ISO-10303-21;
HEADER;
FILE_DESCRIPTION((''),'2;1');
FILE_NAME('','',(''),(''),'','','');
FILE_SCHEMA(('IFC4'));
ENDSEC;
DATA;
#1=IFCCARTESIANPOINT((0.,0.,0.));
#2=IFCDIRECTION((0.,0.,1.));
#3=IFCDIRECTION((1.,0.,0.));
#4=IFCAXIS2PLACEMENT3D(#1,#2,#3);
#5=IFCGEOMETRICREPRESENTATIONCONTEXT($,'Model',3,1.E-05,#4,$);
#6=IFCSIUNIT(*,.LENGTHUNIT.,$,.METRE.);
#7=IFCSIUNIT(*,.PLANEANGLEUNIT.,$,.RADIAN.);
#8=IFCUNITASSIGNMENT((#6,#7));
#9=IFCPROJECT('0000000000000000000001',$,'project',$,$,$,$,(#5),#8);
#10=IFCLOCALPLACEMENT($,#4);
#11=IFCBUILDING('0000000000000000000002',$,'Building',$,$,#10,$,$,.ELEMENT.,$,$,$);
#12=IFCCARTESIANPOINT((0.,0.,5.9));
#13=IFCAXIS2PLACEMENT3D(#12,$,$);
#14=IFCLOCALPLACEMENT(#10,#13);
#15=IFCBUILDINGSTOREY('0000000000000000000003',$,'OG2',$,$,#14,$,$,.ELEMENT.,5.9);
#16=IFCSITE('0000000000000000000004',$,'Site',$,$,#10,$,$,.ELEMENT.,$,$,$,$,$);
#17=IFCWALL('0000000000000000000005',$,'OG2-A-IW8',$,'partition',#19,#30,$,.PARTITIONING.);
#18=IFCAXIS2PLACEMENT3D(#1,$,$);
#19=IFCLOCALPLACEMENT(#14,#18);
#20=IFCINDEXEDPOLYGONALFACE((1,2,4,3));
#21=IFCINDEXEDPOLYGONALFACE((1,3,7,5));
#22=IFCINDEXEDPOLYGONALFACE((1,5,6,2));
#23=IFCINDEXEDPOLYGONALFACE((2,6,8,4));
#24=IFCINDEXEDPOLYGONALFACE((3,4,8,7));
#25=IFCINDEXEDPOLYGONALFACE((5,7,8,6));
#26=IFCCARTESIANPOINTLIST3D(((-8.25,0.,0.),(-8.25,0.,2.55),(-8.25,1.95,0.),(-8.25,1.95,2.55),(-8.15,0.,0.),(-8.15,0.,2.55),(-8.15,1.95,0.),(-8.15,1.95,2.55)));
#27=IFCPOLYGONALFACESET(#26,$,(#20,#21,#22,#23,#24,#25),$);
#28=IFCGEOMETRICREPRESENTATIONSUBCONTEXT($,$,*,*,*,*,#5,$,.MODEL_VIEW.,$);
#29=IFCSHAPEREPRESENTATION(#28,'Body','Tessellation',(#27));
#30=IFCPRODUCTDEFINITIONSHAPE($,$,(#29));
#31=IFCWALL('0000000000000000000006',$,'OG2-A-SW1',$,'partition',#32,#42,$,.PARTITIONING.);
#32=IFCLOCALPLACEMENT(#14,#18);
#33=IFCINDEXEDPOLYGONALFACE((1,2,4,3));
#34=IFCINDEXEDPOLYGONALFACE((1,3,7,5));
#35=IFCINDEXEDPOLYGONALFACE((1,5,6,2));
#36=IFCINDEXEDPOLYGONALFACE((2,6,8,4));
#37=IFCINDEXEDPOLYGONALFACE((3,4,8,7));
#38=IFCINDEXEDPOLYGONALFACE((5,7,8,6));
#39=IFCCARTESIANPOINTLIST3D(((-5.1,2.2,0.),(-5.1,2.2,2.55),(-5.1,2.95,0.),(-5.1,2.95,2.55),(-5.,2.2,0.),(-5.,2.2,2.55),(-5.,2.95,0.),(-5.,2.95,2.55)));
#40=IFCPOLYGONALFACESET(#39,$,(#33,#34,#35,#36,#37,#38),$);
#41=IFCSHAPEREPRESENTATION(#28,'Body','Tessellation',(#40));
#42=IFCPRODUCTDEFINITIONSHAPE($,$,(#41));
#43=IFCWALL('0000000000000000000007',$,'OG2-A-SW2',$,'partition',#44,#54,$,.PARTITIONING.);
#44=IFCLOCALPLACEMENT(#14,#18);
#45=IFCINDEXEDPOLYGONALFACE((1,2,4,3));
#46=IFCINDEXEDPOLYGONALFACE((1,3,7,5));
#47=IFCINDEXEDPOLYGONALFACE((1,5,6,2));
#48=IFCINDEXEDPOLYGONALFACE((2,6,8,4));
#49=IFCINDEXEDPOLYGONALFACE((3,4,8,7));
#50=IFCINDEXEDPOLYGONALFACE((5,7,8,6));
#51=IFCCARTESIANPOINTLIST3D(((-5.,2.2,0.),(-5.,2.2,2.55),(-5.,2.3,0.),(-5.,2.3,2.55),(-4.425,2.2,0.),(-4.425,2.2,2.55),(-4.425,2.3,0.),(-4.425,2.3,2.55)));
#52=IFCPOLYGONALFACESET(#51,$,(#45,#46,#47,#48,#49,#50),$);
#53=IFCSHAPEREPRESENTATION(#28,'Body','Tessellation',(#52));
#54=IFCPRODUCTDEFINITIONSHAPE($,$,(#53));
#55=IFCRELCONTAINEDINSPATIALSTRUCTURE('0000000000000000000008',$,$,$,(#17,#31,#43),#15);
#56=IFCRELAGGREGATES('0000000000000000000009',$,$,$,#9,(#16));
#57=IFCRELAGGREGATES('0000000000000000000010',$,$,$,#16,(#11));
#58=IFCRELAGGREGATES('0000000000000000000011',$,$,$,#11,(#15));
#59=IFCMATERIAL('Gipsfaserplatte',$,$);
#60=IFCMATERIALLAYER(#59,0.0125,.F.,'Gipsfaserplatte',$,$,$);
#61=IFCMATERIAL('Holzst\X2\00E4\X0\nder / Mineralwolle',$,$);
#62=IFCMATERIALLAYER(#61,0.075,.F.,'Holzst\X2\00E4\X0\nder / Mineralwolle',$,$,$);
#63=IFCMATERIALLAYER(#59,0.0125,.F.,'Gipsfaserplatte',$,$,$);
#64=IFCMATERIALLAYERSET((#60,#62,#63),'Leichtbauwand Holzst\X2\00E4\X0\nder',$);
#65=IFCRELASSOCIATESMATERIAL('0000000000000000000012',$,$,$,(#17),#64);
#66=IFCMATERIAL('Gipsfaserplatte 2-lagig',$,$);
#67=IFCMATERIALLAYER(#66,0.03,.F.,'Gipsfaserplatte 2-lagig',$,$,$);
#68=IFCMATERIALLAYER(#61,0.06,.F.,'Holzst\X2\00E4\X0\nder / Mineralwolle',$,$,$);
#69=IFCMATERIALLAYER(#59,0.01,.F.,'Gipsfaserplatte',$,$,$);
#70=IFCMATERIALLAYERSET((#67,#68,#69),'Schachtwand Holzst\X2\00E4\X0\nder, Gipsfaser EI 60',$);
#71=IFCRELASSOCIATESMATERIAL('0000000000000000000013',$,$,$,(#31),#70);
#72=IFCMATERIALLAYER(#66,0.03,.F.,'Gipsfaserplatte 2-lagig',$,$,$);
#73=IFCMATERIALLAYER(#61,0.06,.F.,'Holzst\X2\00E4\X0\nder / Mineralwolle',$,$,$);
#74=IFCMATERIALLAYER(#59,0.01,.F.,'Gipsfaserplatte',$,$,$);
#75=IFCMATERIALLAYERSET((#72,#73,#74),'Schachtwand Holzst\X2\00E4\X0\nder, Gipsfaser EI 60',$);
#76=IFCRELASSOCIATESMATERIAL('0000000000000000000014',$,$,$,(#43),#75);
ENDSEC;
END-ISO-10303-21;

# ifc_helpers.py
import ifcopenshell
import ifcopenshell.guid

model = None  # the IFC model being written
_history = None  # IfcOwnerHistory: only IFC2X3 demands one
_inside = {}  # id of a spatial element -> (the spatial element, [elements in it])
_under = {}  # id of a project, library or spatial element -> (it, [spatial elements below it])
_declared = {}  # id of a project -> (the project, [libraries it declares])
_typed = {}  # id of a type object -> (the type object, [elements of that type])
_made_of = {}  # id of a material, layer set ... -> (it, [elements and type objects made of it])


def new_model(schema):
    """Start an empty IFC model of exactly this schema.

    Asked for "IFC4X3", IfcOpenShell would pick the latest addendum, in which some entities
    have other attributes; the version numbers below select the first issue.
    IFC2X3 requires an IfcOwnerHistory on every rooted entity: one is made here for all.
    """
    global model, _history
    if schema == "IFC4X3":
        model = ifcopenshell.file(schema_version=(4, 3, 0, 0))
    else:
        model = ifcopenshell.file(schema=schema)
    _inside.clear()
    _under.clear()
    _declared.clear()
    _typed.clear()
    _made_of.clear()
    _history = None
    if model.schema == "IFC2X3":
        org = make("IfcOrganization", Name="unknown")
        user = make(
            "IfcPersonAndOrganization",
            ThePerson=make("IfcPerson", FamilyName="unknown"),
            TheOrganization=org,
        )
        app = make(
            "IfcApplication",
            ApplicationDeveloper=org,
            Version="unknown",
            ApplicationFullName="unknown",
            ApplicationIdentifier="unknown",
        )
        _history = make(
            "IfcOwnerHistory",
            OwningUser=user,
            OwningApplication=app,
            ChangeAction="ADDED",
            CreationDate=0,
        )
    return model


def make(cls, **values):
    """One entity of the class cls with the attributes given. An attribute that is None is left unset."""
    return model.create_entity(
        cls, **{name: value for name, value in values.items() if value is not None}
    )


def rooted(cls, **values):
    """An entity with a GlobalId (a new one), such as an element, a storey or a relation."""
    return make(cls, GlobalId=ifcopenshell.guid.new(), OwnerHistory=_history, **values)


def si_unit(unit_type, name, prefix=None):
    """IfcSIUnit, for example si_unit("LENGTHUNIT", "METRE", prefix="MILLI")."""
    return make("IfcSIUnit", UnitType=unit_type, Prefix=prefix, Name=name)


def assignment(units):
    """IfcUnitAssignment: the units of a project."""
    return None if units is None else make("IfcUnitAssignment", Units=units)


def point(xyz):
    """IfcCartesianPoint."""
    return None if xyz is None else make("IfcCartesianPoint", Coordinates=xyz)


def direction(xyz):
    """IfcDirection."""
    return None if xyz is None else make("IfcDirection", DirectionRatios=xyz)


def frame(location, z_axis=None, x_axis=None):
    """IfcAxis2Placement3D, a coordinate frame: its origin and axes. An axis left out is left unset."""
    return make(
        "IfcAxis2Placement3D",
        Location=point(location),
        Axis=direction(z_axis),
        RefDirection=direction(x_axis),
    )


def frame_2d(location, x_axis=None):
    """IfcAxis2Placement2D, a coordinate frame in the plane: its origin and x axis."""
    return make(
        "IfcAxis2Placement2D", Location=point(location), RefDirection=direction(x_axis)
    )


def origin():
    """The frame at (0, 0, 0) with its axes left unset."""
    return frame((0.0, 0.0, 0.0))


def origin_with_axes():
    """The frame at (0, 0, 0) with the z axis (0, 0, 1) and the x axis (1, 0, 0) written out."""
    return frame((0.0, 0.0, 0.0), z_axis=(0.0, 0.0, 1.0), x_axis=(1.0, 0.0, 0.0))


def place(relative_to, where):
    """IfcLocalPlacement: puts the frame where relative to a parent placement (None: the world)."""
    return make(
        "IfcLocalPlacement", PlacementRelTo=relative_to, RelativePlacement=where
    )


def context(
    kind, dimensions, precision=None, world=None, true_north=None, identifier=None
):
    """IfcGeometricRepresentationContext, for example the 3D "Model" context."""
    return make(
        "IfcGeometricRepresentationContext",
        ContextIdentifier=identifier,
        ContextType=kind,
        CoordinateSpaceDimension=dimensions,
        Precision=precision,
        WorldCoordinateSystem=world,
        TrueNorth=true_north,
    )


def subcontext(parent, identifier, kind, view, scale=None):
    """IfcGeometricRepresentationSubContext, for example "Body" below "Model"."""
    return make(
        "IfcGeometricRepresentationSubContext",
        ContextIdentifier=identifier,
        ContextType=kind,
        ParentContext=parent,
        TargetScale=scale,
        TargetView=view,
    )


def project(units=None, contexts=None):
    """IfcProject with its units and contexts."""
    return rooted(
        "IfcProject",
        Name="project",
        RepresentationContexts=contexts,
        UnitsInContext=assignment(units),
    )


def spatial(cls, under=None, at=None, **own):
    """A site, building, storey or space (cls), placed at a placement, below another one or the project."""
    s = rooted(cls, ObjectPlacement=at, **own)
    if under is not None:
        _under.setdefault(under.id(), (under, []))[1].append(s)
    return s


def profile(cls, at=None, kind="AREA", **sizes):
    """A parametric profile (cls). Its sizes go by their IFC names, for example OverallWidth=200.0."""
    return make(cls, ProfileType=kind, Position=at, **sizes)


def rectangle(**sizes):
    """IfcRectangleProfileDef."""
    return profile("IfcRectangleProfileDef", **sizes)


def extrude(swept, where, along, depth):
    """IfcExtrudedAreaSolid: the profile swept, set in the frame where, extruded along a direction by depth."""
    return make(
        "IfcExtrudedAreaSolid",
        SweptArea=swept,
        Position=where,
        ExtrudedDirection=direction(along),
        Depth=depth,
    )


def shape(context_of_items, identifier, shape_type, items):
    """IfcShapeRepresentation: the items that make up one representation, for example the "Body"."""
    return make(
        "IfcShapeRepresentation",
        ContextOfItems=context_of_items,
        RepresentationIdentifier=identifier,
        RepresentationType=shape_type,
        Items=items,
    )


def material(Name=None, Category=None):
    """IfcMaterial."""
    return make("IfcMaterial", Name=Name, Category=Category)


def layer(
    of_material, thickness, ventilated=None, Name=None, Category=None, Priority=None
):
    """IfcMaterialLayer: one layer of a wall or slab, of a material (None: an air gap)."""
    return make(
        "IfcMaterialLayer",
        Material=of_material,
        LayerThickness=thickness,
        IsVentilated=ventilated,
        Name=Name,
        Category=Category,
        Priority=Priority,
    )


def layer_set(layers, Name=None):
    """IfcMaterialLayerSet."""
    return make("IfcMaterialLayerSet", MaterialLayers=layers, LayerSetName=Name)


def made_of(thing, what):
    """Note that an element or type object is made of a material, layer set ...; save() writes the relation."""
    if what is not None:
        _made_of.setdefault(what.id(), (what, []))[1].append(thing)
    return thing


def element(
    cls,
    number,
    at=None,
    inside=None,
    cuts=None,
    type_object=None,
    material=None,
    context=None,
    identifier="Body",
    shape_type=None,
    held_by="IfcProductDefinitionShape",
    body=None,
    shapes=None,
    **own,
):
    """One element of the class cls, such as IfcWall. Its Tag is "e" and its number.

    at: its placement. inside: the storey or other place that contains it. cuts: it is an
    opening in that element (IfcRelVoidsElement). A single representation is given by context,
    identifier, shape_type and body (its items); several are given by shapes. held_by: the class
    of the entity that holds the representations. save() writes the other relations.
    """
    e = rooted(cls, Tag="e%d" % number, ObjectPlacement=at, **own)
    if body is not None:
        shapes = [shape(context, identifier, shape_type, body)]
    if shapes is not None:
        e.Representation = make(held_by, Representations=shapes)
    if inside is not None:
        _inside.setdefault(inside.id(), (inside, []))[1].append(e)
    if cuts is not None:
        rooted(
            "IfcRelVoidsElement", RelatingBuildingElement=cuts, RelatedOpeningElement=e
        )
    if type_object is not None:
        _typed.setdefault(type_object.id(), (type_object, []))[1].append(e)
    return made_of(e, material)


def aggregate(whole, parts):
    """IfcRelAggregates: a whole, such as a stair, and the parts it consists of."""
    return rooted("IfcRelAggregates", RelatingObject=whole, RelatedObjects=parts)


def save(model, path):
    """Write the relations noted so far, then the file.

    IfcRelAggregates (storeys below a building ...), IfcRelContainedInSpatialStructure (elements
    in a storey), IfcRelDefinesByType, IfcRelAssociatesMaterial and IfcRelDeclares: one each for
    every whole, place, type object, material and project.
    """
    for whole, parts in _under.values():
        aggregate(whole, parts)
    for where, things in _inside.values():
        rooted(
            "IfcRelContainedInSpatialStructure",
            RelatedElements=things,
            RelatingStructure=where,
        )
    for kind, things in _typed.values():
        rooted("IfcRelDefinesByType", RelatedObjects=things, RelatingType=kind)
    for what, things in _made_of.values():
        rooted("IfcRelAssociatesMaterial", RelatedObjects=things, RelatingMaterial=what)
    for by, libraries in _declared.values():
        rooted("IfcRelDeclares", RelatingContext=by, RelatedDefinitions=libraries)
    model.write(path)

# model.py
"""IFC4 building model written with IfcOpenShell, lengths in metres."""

from ifc_helpers import new_model, si_unit, frame, frame_2d, origin, origin_with_axes, place, context, subcontext, project, spatial, rectangle, extrude, material, layer, layer_set, element, save


model = new_model("IFC4")

# Units and contexts
model_context = context("Model", 3, precision=1e-05, world=origin_with_axes())
sub_context = subcontext(model_context, None, None, "MODEL_VIEW")
ifc_project = project(units=[si_unit("LENGTHUNIT", "METRE"), si_unit("PLANEANGLEUNIT", "RADIAN")], contexts=[model_context])

# Site, building, storey
placement = place(None, origin_with_axes())
site = spatial("IfcSite", under=ifc_project, at=placement, Name="Site", CompositionType="ELEMENT")
building = spatial("IfcBuilding", under=site, at=placement, Name="Building", CompositionType="ELEMENT")
storey_placement = place(placement, frame((0.0, 0.0, 5.9)))
storey = spatial("IfcBuildingStorey", under=building, at=storey_placement, Name="OG2", CompositionType="ELEMENT", Elevation=5.9)

# Shared definitions
ifc_material_1 = material(Name="Gipsfaserplatte")

# Shared definitions
ifc_material_2 = material(Name="Gipsfaserplatte 2-lagig")

# Shared definitions
ifc_material_3 = material(Name="Holzständer / Mineralwolle")

# Walls
ifc_layer_1 = layer(ifc_material_1, 0.0125, ventilated=False, Name="Gipsfaserplatte")
ifc_layer_2 = layer(ifc_material_3, 0.075, ventilated=False, Name="Holzständer / Mineralwolle")
ifc_layer_3 = layer(ifc_material_1, 0.0125, ventilated=False, Name="Gipsfaserplatte")
ifc_layer_set_1 = layer_set([ifc_layer_1, ifc_layer_2, ifc_layer_3], Name="Leichtbauwand Holzständer")
wall_1_placement = place(storey_placement, frame((-8.2, 0.0, 0.0), z_axis=(0.0, 0.0, 1.0), x_axis=(0.0, 1.0, 0.0)))
element("IfcWall", 1, at=wall_1_placement, inside=storey, material=ifc_layer_set_1, Name="OG2-A-IW8", ObjectType="partition", PredefinedType="PARTITIONING", context=sub_context, shape_type="SweptSolid", body=[
    extrude(rectangle(XDim=1.95, YDim=0.1, at=frame_2d((0.975, 0.0))), origin(), (0.0, 0.0, 1.0), 2.55),
])
ifc_layer_4 = layer(ifc_material_2, 0.03, ventilated=False, Name="Gipsfaserplatte 2-lagig")
ifc_layer_5 = layer(ifc_material_3, 0.06, ventilated=False, Name="Holzständer / Mineralwolle")
ifc_layer_6 = layer(ifc_material_1, 0.01, ventilated=False, Name="Gipsfaserplatte")
ifc_layer_set_2 = layer_set([ifc_layer_4, ifc_layer_5, ifc_layer_6], Name="Schachtwand Holzständer, Gipsfaser EI 60")
wall_2_placement = place(storey_placement, frame((-5.05, 2.2, 0.0), z_axis=(0.0, 0.0, 1.0), x_axis=(0.0, 1.0, 0.0)))
element("IfcWall", 2, at=wall_2_placement, inside=storey, material=ifc_layer_set_2, Name="OG2-A-SW1", ObjectType="partition", PredefinedType="PARTITIONING", context=sub_context, shape_type="SweptSolid", body=[
    extrude(rectangle(XDim=0.75, YDim=0.1, at=frame_2d((0.375, 0.0))), origin(), (0.0, 0.0, 1.0), 2.55),
])
ifc_layer_7 = layer(ifc_material_2, 0.03, ventilated=False, Name="Gipsfaserplatte 2-lagig")
ifc_layer_8 = layer(ifc_material_3, 0.06, ventilated=False, Name="Holzständer / Mineralwolle")
ifc_layer_9 = layer(ifc_material_1, 0.01, ventilated=False, Name="Gipsfaserplatte")
ifc_layer_set_3 = layer_set([ifc_layer_7, ifc_layer_8, ifc_layer_9], Name="Schachtwand Holzständer, Gipsfaser EI 60")
wall_3_placement = place(storey_placement, frame((-5.0, 2.25, 0.0), z_axis=(0.0, 0.0, 1.0), x_axis=(1.0, 0.0, 0.0)))
element("IfcWall", 3, at=wall_3_placement, inside=storey, material=ifc_layer_set_3, Name="OG2-A-SW2", ObjectType="partition", PredefinedType="PARTITIONING", context=sub_context, shape_type="SweptSolid", body=[
    extrude(rectangle(XDim=0.575, YDim=0.1, at=frame_2d((0.2875, 0.0))), origin(), (0.0, 0.0, 1.0), 2.55),
])

save(model, "model.ifc")
